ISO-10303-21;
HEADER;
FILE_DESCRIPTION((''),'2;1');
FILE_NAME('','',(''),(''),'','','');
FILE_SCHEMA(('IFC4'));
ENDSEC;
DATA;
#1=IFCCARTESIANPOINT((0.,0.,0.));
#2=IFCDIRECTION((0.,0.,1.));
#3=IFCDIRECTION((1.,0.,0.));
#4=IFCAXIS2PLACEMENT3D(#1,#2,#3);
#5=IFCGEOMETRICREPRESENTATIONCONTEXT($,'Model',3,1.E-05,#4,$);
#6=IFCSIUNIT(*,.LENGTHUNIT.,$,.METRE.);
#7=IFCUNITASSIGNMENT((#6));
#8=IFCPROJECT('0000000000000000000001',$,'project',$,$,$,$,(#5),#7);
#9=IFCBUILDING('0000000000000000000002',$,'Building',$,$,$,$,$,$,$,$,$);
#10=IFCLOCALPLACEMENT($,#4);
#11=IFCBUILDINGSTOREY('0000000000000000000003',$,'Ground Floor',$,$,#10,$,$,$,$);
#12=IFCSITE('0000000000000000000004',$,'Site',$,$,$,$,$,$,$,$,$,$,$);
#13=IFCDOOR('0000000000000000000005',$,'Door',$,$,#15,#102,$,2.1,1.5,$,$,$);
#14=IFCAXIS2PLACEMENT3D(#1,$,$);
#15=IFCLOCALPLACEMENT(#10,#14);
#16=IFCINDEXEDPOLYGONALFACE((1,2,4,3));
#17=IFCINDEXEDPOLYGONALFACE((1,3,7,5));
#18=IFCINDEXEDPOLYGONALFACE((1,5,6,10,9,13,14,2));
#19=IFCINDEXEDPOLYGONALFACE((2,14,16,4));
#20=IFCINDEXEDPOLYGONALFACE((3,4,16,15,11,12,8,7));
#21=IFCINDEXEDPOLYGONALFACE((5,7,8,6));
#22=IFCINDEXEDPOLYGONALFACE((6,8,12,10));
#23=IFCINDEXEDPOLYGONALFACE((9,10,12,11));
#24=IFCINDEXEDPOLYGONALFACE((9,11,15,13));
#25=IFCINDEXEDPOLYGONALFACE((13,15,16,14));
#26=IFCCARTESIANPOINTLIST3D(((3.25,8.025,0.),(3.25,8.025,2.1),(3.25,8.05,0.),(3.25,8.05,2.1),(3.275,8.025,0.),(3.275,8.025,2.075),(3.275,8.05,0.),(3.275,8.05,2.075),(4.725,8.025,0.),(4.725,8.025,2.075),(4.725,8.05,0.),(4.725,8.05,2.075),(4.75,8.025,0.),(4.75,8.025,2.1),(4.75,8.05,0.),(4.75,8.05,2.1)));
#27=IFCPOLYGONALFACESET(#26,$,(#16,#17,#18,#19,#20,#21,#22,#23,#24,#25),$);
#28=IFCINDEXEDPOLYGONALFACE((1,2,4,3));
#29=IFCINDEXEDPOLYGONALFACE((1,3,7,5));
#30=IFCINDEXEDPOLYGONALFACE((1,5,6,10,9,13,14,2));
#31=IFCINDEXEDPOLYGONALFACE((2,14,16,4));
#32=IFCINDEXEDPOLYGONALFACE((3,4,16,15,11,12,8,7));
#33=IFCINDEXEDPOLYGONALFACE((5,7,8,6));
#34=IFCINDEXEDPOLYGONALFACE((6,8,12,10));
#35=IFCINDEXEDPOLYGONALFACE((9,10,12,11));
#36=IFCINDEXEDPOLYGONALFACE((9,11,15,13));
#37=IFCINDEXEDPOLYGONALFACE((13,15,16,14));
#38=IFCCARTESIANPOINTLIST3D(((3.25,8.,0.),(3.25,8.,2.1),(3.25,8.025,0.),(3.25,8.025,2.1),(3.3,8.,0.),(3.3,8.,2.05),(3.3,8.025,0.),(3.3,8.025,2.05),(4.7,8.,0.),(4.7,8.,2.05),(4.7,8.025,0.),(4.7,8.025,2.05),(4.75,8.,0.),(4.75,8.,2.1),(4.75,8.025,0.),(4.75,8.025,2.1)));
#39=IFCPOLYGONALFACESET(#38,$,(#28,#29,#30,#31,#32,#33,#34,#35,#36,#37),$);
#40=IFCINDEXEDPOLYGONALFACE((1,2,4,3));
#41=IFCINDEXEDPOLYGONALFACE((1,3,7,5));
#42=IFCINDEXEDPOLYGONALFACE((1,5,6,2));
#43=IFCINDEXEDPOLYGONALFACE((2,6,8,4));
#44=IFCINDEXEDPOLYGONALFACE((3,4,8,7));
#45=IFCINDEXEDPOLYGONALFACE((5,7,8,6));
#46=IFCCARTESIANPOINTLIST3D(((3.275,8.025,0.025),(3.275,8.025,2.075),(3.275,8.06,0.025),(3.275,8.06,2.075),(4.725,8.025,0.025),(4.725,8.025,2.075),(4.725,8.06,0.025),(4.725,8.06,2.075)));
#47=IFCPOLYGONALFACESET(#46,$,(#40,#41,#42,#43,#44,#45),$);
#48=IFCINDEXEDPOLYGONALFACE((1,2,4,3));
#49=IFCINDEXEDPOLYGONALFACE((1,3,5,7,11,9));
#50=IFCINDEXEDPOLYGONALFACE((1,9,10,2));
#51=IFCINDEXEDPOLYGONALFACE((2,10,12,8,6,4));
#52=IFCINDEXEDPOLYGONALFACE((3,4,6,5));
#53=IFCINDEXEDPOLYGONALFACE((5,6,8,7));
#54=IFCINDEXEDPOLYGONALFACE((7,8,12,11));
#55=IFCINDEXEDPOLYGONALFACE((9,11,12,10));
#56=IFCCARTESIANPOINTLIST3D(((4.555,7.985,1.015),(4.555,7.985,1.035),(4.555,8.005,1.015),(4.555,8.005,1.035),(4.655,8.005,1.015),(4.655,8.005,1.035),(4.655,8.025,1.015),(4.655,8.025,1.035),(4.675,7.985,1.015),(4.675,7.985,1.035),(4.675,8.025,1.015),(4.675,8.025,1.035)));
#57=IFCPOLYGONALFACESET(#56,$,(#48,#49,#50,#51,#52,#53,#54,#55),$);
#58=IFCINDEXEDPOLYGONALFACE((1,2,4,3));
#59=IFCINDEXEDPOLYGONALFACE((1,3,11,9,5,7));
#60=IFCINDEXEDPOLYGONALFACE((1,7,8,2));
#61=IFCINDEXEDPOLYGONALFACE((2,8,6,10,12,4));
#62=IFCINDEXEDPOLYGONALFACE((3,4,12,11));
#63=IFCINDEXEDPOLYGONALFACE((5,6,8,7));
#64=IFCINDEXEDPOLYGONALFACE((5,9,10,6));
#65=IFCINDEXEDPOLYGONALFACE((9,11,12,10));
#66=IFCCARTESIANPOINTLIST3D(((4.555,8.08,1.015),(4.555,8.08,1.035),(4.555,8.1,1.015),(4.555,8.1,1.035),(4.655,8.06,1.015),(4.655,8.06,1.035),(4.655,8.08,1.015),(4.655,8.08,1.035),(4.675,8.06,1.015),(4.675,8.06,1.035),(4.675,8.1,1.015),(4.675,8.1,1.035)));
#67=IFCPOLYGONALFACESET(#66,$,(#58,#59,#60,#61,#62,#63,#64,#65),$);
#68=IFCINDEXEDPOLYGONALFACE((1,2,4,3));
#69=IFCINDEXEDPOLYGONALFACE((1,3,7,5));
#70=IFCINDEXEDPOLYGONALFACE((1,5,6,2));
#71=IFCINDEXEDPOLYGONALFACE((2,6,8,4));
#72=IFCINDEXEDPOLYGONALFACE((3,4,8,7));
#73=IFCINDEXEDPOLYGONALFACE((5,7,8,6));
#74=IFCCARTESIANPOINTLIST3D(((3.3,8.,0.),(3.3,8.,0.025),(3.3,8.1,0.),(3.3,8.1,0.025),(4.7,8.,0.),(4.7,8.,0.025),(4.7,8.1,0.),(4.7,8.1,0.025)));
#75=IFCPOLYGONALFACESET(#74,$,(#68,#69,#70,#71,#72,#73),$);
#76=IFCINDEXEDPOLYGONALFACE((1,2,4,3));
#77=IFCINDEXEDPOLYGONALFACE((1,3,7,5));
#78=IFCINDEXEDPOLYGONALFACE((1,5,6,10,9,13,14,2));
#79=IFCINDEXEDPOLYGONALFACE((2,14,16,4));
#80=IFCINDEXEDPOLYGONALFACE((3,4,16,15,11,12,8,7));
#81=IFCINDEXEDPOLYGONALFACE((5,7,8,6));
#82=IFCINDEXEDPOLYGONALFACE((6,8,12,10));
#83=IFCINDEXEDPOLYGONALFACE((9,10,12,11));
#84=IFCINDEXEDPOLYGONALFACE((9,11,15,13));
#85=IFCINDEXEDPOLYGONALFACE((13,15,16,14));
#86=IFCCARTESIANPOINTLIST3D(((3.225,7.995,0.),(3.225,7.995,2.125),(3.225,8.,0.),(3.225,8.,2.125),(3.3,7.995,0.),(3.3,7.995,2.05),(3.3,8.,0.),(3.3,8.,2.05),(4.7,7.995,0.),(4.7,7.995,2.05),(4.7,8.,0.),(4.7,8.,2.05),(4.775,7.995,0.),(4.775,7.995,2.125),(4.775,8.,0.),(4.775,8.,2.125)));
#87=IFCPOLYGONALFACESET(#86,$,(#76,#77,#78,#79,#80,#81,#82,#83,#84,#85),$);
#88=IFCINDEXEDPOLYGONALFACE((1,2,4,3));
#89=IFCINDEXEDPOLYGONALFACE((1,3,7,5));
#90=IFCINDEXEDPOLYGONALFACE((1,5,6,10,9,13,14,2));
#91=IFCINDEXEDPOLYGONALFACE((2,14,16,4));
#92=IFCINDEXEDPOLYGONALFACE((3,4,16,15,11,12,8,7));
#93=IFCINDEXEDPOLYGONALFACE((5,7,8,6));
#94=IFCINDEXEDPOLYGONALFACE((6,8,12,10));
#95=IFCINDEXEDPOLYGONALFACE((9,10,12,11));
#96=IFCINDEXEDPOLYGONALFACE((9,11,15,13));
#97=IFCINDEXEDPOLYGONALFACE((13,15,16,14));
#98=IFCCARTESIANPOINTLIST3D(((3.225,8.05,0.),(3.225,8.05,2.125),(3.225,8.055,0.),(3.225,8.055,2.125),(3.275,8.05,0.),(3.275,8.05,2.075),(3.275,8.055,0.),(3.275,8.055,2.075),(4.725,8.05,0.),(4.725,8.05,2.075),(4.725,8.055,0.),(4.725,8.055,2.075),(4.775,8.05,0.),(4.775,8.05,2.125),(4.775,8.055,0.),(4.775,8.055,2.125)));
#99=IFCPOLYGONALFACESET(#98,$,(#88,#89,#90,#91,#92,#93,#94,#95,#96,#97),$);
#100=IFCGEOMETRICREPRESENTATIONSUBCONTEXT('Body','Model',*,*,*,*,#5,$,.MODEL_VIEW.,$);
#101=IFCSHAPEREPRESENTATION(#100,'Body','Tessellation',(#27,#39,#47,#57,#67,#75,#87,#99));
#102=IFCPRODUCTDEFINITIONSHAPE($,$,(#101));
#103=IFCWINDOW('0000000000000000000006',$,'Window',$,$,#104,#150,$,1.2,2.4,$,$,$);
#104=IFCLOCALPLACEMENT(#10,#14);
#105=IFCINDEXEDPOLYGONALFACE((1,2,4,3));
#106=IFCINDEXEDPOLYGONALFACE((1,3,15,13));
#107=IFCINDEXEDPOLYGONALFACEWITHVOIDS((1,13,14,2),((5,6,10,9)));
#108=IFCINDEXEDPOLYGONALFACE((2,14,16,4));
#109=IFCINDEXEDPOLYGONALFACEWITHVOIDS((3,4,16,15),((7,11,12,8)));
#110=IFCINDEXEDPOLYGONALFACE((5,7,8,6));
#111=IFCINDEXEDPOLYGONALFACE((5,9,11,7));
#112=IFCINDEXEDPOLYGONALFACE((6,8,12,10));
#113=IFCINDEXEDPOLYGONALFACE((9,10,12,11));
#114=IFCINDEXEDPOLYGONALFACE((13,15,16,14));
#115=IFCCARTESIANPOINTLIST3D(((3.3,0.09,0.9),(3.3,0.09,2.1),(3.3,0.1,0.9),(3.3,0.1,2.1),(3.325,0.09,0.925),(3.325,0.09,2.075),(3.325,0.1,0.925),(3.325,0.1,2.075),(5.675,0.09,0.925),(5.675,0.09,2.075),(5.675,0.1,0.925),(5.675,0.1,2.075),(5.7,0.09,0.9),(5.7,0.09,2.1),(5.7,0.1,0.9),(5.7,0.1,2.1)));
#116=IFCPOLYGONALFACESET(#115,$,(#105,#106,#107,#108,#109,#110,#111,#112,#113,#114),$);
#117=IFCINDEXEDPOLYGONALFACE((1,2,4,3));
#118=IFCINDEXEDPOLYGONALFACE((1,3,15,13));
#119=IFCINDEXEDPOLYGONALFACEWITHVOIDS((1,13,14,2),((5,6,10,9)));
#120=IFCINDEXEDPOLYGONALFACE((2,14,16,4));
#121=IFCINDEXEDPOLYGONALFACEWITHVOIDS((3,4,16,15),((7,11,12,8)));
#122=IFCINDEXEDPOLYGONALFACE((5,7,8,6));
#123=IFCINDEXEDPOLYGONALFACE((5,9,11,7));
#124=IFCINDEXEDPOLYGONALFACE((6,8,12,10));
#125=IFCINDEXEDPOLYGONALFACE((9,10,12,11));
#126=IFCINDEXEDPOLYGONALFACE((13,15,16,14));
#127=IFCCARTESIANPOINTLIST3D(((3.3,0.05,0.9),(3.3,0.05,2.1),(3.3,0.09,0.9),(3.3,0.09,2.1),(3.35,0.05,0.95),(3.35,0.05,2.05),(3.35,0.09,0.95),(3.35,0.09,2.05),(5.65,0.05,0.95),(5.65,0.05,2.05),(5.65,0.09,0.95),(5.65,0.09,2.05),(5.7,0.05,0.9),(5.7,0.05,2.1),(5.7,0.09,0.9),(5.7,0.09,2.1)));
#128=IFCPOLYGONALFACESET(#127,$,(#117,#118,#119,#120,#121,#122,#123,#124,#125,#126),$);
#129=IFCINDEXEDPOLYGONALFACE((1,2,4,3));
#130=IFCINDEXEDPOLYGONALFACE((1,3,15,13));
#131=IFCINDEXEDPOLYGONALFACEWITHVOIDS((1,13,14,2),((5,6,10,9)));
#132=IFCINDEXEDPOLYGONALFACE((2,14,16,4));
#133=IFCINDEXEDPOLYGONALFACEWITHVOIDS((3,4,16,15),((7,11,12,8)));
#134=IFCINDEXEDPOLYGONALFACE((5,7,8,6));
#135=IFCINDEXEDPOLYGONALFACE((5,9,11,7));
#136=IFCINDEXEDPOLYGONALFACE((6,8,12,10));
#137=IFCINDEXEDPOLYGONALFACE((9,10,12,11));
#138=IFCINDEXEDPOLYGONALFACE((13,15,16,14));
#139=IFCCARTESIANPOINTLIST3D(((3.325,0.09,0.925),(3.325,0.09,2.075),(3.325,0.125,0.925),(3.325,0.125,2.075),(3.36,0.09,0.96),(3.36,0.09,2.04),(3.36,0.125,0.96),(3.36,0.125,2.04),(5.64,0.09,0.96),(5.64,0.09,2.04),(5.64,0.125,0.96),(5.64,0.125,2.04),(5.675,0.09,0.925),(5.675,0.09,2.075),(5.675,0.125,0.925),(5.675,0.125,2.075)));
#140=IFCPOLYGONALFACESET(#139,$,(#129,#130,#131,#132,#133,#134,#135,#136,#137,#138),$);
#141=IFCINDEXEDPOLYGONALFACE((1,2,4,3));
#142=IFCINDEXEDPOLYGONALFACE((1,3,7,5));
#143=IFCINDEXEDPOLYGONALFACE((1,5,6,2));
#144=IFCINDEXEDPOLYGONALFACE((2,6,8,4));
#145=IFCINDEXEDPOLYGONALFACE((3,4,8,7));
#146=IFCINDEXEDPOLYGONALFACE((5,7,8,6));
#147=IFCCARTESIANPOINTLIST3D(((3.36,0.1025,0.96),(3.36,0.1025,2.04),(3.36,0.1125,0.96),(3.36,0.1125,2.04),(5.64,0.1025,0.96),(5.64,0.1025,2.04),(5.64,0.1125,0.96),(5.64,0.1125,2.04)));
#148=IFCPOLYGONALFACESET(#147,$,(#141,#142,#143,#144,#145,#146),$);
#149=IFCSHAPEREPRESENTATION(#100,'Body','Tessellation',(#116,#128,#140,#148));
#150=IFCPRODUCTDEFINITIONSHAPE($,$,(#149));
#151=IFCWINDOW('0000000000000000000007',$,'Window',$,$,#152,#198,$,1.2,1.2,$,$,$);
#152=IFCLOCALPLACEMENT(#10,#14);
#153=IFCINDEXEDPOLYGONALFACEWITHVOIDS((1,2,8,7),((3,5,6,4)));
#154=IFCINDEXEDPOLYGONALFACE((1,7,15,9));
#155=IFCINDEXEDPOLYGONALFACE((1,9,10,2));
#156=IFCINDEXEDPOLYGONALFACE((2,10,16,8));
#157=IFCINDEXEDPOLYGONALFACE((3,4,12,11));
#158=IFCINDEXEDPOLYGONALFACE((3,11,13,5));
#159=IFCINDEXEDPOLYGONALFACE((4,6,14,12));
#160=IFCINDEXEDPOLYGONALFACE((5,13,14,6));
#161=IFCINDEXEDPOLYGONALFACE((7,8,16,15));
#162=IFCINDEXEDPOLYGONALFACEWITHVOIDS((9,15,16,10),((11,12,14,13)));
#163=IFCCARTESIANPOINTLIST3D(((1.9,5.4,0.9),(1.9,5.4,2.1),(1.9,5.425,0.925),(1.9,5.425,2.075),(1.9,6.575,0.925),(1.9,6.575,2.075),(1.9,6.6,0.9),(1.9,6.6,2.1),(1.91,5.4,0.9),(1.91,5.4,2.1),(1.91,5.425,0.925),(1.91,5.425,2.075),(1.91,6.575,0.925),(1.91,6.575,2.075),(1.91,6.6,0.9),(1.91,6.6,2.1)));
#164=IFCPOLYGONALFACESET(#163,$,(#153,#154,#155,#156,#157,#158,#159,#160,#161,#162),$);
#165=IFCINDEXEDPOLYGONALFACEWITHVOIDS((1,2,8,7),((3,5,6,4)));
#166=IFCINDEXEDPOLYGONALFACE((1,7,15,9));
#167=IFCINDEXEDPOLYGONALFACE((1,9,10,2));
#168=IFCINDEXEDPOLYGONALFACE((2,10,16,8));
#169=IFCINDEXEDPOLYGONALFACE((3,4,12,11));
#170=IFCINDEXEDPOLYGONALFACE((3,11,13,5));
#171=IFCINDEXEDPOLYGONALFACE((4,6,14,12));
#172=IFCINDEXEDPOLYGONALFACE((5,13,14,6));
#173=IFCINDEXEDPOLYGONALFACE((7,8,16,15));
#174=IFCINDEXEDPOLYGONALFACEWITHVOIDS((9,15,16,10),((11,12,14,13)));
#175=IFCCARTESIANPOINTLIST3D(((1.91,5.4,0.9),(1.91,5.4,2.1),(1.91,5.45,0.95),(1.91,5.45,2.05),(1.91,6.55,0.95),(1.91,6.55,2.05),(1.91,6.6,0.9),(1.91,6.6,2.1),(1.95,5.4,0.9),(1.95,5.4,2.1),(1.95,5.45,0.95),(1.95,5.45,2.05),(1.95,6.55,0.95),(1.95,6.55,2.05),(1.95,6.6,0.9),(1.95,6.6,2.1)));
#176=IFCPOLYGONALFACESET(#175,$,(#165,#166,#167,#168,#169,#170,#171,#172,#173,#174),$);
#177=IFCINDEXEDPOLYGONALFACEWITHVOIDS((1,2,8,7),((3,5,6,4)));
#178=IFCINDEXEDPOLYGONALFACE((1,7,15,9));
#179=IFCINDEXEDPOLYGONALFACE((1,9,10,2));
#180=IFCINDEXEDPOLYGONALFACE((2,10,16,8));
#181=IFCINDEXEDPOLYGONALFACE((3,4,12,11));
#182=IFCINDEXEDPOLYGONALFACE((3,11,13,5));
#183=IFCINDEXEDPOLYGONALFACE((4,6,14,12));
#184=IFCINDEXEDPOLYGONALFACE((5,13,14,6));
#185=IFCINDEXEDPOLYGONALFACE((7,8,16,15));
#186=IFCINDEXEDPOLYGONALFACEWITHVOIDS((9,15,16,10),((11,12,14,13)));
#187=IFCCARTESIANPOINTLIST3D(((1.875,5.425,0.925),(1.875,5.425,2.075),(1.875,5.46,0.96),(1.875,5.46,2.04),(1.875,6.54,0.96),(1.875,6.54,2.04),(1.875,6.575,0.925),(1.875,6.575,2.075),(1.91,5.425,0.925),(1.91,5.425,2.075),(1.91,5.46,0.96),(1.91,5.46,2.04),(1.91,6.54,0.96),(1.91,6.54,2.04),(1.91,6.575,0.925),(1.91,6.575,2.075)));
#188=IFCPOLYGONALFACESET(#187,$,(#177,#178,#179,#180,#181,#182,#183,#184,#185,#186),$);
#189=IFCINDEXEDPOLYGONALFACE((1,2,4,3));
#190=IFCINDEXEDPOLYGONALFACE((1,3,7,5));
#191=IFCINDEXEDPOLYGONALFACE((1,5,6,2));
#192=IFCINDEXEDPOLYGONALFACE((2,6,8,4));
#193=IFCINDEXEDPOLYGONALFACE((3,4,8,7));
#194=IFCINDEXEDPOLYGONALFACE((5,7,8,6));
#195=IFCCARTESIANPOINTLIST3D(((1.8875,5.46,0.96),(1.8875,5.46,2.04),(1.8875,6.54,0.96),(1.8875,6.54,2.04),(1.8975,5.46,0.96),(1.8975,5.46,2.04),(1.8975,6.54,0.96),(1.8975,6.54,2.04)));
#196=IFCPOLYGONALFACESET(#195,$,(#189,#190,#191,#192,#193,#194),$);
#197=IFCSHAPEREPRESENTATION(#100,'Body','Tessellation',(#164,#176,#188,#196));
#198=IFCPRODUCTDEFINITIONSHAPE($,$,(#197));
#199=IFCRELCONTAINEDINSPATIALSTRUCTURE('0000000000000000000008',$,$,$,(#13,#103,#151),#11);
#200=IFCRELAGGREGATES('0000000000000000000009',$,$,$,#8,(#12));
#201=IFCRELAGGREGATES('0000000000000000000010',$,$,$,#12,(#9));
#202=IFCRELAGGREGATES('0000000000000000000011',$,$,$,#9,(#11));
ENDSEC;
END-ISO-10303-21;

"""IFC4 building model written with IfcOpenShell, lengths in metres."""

from ifc_helpers import new_model, si_unit, frame, origin_with_axes, place, context, subcontext, project, spatial, line, indexed_curve, outline, extrude, element, save


model = new_model("IFC4")

# Units and contexts
model_context = context("Model", 3, precision=1e-05, world=origin_with_axes())
body_context = subcontext(model_context, "Body", "Model", "MODEL_VIEW")
ifc_project = project(units=[si_unit("LENGTHUNIT", "METRE")], contexts=[model_context])

# Site, building, storey
site = spatial("IfcSite", under=ifc_project, Name="Site")
building = spatial("IfcBuilding", under=site, Name="Building")
storey_placement = place(None, origin_with_axes())
storey = spatial("IfcBuildingStorey", under=building, at=storey_placement, Name="Ground Floor")

# Door
door_1_placement = place(storey_placement, frame((3.25, 8.0, 0.0), z_axis=(0.0, 0.0, 1.0), x_axis=(1.0, 0.0, 0.0)))
element("IfcDoor", 1, at=door_1_placement, inside=storey, Name="Door", OverallHeight=2.1, OverallWidth=1.5, context=body_context, shape_type="SweptSolid", body=[
    extrude(outline(indexed_curve([(0.0, 0.0), (0.0, 2.1), (1.5, 2.1), (1.5, 0.0), (1.475, 0.0), (1.475, 2.075), (0.025, 2.075), (0.025, 0.0)], segments=[line(1, 2, 3, 4, 5, 6, 7, 8, 1)])), frame((0.0, 0.025, 0.0), z_axis=(0.0, -1.0, 0.0), x_axis=(1.0, 0.0, 0.0)), (0.0, 0.0, -1.0), 0.025),
    extrude(outline(indexed_curve([(0.0, 0.0), (0.0, 2.1), (1.5, 2.1), (1.5, 0.0), (1.45, 0.0), (1.45, 2.05), (0.05, 2.05), (0.05, 0.0)], segments=[line(1, 2, 3, 4, 5, 6, 7, 8, 1)])), frame((0.0, 0.0, 0.0), z_axis=(0.0, -1.0, 0.0), x_axis=(1.0, 0.0, 0.0)), (0.0, 0.0, -1.0), 0.025),
    extrude(outline(indexed_curve([(0.0, 0.0), (1.45, 0.0), (1.45, 0.035), (0.0, 0.035)], segments=[line(1, 2, 3, 4, 1)])), frame((0.025, 0.025, 0.025), z_axis=(0.0, 0.0, 1.0), x_axis=(1.0, 0.0, 0.0)), (0.0, 0.0, 1.0), 2.05),
    extrude(outline(indexed_curve([(0.0, 0.0), (0.0, -0.04), (-0.12, -0.04), (-0.12, -0.02), (-0.02, -0.02), (-0.02, 0.0)], segments=[line(1, 2, 3, 4, 5, 6, 1)])), frame((1.425, 0.025, 1.015), z_axis=(0.0, 0.0, 1.0), x_axis=(1.0, 0.0, 0.0)), (0.0, 0.0, 1.0), 0.02),
    extrude(outline(indexed_curve([(0.0, 0.0), (0.0, 0.04), (-0.12, 0.04), (-0.12, 0.02), (-0.02, 0.02), (-0.02, 0.0)], segments=[line(1, 2, 3, 4, 5, 6, 1)])), frame((1.425, 0.06, 1.015), z_axis=(0.0, 0.0, 1.0), x_axis=(1.0, 0.0, 0.0)), (0.0, 0.0, 1.0), 0.02),
    extrude(outline(indexed_curve([(0.0, 0.0), (1.4, 0.0), (1.4, 0.1), (0.0, 0.1)], segments=[line(1, 2, 3, 4, 1)])), frame((0.05, 0.0, 0.0), z_axis=(0.0, 0.0, 1.0), x_axis=(1.0, 0.0, 0.0)), (0.0, 0.0, 1.0), 0.025),
    extrude(outline(indexed_curve([(0.0, 0.0), (0.0, 2.125), (1.55, 2.125), (1.55, 0.0), (1.475, 0.0), (1.475, 2.05), (0.075, 2.05), (0.075, 0.0)], segments=[line(1, 2, 3, 4, 5, 6, 7, 8, 1)])), frame((-0.025, -0.005, 0.0), z_axis=(0.0, -1.0, 0.0), x_axis=(1.0, 0.0, 0.0)), (0.0, 0.0, -1.0), 0.005),
    extrude(outline(indexed_curve([(0.0, 0.0), (0.0, 2.125), (1.55, 2.125), (1.55, 0.0), (1.5, 0.0), (1.5, 2.075), (0.05, 2.075), (0.05, 0.0)], segments=[line(1, 2, 3, 4, 5, 6, 7, 8, 1)])), frame((-0.025, 0.05, 0.0), z_axis=(0.0, -1.0, 0.0), x_axis=(1.0, 0.0, 0.0)), (0.0, 0.0, -1.0), 0.005),
])

# Windows
window_1_placement = place(storey_placement, frame((3.3, 0.0, 0.9), z_axis=(0.0, 0.0, 1.0), x_axis=(1.0, 0.0, 0.0)))
element("IfcWindow", 2, at=window_1_placement, inside=storey, Name="Window", OverallHeight=1.2, OverallWidth=2.4, context=body_context, shape_type="SweptSolid", body=[
    extrude(outline(indexed_curve([(0.0, 0.0), (2.4, 0.0), (2.4, 1.2), (0.0, 1.2)], segments=[line(1, 2, 3, 4, 1)]), holes=[indexed_curve([(0.025, 0.025), (2.375, 0.025), (2.375, 1.175), (0.025, 1.175)], segments=[line(1, 2, 3, 4, 1)])]), frame((0.0, 0.09, 0.0), z_axis=(0.0, -1.0, 0.0), x_axis=(1.0, 0.0, 0.0)), (0.0, 0.0, -1.0), 0.01),
    extrude(outline(indexed_curve([(0.0, 0.0), (2.4, 0.0), (2.4, 1.2), (0.0, 1.2)], segments=[line(1, 2, 3, 4, 1)]), holes=[indexed_curve([(0.05, 0.05), (2.35, 0.05), (2.35, 1.15), (0.05, 1.15)], segments=[line(1, 2, 3, 4, 1)])]), frame((0.0, 0.05, 0.0), z_axis=(0.0, -1.0, 0.0), x_axis=(1.0, 0.0, 0.0)), (0.0, 0.0, -1.0), 0.04),
    extrude(outline(indexed_curve([(0.0, 0.0), (2.35, 0.0), (2.35, 1.15), (0.0, 1.15)], segments=[line(1, 2, 3, 4, 1)]), holes=[indexed_curve([(0.035, 0.035), (2.315, 0.035), (2.315, 1.115), (0.035, 1.115)], segments=[line(1, 2, 3, 4, 1)])]), frame((0.025, 0.09, 0.025), z_axis=(0.0, -1.0, 0.0), x_axis=(1.0, 0.0, 0.0)), (0.0, 0.0, -1.0), 0.035),
    extrude(outline(indexed_curve([(0.035, 0.035), (2.315, 0.035), (2.315, 1.115), (0.035, 1.115)], segments=[line(1, 2, 3, 4, 1)])), frame((0.025, 0.1025, 0.025), z_axis=(0.0, -1.0, 0.0), x_axis=(1.0, 0.0, 0.0)), (0.0, 0.0, -1.0), 0.01),
])
window_2_placement = place(storey_placement, frame((2.0, 5.4, 0.9), z_axis=(0.0, 0.0, 1.0), x_axis=(0.0, 1.0, 0.0)))
element("IfcWindow", 3, at=window_2_placement, inside=storey, Name="Window", OverallHeight=1.2, OverallWidth=1.2, context=body_context, shape_type="SweptSolid", body=[
    extrude(outline(indexed_curve([(0.0, 0.0), (1.2, 0.0), (1.2, 1.2), (0.0, 1.2)], segments=[line(1, 2, 3, 4, 1)]), holes=[indexed_curve([(0.025, 0.025), (1.175, 0.025), (1.175, 1.175), (0.025, 1.175)], segments=[line(1, 2, 3, 4, 1)])]), frame((0.0, 0.09, 0.0), z_axis=(0.0, -1.0, 0.0), x_axis=(1.0, 0.0, 0.0)), (0.0, 0.0, -1.0), 0.01),
    extrude(outline(indexed_curve([(0.0, 0.0), (1.2, 0.0), (1.2, 1.2), (0.0, 1.2)], segments=[line(1, 2, 3, 4, 1)]), holes=[indexed_curve([(0.05, 0.05), (1.15, 0.05), (1.15, 1.15), (0.05, 1.15)], segments=[line(1, 2, 3, 4, 1)])]), frame((0.0, 0.05, 0.0), z_axis=(0.0, -1.0, 0.0), x_axis=(1.0, 0.0, 0.0)), (0.0, 0.0, -1.0), 0.04),
    extrude(outline(indexed_curve([(0.0, 0.0), (1.15, 0.0), (1.15, 1.15), (0.0, 1.15)], segments=[line(1, 2, 3, 4, 1)]), holes=[indexed_curve([(0.035, 0.035), (1.115, 0.035), (1.115, 1.115), (0.035, 1.115)], segments=[line(1, 2, 3, 4, 1)])]), frame((0.025, 0.09, 0.025), z_axis=(0.0, -1.0, 0.0), x_axis=(1.0, 0.0, 0.0)), (0.0, 0.0, -1.0), 0.035),
    extrude(outline(indexed_curve([(0.035, 0.035), (1.115, 0.035), (1.115, 1.115), (0.035, 1.115)], segments=[line(1, 2, 3, 4, 1)])), frame((0.025, 0.1025, 0.025), z_axis=(0.0, -1.0, 0.0), x_axis=(1.0, 0.0, 0.0)), (0.0, 0.0, -1.0), 0.01),
])

save(model, "model.ifc")
